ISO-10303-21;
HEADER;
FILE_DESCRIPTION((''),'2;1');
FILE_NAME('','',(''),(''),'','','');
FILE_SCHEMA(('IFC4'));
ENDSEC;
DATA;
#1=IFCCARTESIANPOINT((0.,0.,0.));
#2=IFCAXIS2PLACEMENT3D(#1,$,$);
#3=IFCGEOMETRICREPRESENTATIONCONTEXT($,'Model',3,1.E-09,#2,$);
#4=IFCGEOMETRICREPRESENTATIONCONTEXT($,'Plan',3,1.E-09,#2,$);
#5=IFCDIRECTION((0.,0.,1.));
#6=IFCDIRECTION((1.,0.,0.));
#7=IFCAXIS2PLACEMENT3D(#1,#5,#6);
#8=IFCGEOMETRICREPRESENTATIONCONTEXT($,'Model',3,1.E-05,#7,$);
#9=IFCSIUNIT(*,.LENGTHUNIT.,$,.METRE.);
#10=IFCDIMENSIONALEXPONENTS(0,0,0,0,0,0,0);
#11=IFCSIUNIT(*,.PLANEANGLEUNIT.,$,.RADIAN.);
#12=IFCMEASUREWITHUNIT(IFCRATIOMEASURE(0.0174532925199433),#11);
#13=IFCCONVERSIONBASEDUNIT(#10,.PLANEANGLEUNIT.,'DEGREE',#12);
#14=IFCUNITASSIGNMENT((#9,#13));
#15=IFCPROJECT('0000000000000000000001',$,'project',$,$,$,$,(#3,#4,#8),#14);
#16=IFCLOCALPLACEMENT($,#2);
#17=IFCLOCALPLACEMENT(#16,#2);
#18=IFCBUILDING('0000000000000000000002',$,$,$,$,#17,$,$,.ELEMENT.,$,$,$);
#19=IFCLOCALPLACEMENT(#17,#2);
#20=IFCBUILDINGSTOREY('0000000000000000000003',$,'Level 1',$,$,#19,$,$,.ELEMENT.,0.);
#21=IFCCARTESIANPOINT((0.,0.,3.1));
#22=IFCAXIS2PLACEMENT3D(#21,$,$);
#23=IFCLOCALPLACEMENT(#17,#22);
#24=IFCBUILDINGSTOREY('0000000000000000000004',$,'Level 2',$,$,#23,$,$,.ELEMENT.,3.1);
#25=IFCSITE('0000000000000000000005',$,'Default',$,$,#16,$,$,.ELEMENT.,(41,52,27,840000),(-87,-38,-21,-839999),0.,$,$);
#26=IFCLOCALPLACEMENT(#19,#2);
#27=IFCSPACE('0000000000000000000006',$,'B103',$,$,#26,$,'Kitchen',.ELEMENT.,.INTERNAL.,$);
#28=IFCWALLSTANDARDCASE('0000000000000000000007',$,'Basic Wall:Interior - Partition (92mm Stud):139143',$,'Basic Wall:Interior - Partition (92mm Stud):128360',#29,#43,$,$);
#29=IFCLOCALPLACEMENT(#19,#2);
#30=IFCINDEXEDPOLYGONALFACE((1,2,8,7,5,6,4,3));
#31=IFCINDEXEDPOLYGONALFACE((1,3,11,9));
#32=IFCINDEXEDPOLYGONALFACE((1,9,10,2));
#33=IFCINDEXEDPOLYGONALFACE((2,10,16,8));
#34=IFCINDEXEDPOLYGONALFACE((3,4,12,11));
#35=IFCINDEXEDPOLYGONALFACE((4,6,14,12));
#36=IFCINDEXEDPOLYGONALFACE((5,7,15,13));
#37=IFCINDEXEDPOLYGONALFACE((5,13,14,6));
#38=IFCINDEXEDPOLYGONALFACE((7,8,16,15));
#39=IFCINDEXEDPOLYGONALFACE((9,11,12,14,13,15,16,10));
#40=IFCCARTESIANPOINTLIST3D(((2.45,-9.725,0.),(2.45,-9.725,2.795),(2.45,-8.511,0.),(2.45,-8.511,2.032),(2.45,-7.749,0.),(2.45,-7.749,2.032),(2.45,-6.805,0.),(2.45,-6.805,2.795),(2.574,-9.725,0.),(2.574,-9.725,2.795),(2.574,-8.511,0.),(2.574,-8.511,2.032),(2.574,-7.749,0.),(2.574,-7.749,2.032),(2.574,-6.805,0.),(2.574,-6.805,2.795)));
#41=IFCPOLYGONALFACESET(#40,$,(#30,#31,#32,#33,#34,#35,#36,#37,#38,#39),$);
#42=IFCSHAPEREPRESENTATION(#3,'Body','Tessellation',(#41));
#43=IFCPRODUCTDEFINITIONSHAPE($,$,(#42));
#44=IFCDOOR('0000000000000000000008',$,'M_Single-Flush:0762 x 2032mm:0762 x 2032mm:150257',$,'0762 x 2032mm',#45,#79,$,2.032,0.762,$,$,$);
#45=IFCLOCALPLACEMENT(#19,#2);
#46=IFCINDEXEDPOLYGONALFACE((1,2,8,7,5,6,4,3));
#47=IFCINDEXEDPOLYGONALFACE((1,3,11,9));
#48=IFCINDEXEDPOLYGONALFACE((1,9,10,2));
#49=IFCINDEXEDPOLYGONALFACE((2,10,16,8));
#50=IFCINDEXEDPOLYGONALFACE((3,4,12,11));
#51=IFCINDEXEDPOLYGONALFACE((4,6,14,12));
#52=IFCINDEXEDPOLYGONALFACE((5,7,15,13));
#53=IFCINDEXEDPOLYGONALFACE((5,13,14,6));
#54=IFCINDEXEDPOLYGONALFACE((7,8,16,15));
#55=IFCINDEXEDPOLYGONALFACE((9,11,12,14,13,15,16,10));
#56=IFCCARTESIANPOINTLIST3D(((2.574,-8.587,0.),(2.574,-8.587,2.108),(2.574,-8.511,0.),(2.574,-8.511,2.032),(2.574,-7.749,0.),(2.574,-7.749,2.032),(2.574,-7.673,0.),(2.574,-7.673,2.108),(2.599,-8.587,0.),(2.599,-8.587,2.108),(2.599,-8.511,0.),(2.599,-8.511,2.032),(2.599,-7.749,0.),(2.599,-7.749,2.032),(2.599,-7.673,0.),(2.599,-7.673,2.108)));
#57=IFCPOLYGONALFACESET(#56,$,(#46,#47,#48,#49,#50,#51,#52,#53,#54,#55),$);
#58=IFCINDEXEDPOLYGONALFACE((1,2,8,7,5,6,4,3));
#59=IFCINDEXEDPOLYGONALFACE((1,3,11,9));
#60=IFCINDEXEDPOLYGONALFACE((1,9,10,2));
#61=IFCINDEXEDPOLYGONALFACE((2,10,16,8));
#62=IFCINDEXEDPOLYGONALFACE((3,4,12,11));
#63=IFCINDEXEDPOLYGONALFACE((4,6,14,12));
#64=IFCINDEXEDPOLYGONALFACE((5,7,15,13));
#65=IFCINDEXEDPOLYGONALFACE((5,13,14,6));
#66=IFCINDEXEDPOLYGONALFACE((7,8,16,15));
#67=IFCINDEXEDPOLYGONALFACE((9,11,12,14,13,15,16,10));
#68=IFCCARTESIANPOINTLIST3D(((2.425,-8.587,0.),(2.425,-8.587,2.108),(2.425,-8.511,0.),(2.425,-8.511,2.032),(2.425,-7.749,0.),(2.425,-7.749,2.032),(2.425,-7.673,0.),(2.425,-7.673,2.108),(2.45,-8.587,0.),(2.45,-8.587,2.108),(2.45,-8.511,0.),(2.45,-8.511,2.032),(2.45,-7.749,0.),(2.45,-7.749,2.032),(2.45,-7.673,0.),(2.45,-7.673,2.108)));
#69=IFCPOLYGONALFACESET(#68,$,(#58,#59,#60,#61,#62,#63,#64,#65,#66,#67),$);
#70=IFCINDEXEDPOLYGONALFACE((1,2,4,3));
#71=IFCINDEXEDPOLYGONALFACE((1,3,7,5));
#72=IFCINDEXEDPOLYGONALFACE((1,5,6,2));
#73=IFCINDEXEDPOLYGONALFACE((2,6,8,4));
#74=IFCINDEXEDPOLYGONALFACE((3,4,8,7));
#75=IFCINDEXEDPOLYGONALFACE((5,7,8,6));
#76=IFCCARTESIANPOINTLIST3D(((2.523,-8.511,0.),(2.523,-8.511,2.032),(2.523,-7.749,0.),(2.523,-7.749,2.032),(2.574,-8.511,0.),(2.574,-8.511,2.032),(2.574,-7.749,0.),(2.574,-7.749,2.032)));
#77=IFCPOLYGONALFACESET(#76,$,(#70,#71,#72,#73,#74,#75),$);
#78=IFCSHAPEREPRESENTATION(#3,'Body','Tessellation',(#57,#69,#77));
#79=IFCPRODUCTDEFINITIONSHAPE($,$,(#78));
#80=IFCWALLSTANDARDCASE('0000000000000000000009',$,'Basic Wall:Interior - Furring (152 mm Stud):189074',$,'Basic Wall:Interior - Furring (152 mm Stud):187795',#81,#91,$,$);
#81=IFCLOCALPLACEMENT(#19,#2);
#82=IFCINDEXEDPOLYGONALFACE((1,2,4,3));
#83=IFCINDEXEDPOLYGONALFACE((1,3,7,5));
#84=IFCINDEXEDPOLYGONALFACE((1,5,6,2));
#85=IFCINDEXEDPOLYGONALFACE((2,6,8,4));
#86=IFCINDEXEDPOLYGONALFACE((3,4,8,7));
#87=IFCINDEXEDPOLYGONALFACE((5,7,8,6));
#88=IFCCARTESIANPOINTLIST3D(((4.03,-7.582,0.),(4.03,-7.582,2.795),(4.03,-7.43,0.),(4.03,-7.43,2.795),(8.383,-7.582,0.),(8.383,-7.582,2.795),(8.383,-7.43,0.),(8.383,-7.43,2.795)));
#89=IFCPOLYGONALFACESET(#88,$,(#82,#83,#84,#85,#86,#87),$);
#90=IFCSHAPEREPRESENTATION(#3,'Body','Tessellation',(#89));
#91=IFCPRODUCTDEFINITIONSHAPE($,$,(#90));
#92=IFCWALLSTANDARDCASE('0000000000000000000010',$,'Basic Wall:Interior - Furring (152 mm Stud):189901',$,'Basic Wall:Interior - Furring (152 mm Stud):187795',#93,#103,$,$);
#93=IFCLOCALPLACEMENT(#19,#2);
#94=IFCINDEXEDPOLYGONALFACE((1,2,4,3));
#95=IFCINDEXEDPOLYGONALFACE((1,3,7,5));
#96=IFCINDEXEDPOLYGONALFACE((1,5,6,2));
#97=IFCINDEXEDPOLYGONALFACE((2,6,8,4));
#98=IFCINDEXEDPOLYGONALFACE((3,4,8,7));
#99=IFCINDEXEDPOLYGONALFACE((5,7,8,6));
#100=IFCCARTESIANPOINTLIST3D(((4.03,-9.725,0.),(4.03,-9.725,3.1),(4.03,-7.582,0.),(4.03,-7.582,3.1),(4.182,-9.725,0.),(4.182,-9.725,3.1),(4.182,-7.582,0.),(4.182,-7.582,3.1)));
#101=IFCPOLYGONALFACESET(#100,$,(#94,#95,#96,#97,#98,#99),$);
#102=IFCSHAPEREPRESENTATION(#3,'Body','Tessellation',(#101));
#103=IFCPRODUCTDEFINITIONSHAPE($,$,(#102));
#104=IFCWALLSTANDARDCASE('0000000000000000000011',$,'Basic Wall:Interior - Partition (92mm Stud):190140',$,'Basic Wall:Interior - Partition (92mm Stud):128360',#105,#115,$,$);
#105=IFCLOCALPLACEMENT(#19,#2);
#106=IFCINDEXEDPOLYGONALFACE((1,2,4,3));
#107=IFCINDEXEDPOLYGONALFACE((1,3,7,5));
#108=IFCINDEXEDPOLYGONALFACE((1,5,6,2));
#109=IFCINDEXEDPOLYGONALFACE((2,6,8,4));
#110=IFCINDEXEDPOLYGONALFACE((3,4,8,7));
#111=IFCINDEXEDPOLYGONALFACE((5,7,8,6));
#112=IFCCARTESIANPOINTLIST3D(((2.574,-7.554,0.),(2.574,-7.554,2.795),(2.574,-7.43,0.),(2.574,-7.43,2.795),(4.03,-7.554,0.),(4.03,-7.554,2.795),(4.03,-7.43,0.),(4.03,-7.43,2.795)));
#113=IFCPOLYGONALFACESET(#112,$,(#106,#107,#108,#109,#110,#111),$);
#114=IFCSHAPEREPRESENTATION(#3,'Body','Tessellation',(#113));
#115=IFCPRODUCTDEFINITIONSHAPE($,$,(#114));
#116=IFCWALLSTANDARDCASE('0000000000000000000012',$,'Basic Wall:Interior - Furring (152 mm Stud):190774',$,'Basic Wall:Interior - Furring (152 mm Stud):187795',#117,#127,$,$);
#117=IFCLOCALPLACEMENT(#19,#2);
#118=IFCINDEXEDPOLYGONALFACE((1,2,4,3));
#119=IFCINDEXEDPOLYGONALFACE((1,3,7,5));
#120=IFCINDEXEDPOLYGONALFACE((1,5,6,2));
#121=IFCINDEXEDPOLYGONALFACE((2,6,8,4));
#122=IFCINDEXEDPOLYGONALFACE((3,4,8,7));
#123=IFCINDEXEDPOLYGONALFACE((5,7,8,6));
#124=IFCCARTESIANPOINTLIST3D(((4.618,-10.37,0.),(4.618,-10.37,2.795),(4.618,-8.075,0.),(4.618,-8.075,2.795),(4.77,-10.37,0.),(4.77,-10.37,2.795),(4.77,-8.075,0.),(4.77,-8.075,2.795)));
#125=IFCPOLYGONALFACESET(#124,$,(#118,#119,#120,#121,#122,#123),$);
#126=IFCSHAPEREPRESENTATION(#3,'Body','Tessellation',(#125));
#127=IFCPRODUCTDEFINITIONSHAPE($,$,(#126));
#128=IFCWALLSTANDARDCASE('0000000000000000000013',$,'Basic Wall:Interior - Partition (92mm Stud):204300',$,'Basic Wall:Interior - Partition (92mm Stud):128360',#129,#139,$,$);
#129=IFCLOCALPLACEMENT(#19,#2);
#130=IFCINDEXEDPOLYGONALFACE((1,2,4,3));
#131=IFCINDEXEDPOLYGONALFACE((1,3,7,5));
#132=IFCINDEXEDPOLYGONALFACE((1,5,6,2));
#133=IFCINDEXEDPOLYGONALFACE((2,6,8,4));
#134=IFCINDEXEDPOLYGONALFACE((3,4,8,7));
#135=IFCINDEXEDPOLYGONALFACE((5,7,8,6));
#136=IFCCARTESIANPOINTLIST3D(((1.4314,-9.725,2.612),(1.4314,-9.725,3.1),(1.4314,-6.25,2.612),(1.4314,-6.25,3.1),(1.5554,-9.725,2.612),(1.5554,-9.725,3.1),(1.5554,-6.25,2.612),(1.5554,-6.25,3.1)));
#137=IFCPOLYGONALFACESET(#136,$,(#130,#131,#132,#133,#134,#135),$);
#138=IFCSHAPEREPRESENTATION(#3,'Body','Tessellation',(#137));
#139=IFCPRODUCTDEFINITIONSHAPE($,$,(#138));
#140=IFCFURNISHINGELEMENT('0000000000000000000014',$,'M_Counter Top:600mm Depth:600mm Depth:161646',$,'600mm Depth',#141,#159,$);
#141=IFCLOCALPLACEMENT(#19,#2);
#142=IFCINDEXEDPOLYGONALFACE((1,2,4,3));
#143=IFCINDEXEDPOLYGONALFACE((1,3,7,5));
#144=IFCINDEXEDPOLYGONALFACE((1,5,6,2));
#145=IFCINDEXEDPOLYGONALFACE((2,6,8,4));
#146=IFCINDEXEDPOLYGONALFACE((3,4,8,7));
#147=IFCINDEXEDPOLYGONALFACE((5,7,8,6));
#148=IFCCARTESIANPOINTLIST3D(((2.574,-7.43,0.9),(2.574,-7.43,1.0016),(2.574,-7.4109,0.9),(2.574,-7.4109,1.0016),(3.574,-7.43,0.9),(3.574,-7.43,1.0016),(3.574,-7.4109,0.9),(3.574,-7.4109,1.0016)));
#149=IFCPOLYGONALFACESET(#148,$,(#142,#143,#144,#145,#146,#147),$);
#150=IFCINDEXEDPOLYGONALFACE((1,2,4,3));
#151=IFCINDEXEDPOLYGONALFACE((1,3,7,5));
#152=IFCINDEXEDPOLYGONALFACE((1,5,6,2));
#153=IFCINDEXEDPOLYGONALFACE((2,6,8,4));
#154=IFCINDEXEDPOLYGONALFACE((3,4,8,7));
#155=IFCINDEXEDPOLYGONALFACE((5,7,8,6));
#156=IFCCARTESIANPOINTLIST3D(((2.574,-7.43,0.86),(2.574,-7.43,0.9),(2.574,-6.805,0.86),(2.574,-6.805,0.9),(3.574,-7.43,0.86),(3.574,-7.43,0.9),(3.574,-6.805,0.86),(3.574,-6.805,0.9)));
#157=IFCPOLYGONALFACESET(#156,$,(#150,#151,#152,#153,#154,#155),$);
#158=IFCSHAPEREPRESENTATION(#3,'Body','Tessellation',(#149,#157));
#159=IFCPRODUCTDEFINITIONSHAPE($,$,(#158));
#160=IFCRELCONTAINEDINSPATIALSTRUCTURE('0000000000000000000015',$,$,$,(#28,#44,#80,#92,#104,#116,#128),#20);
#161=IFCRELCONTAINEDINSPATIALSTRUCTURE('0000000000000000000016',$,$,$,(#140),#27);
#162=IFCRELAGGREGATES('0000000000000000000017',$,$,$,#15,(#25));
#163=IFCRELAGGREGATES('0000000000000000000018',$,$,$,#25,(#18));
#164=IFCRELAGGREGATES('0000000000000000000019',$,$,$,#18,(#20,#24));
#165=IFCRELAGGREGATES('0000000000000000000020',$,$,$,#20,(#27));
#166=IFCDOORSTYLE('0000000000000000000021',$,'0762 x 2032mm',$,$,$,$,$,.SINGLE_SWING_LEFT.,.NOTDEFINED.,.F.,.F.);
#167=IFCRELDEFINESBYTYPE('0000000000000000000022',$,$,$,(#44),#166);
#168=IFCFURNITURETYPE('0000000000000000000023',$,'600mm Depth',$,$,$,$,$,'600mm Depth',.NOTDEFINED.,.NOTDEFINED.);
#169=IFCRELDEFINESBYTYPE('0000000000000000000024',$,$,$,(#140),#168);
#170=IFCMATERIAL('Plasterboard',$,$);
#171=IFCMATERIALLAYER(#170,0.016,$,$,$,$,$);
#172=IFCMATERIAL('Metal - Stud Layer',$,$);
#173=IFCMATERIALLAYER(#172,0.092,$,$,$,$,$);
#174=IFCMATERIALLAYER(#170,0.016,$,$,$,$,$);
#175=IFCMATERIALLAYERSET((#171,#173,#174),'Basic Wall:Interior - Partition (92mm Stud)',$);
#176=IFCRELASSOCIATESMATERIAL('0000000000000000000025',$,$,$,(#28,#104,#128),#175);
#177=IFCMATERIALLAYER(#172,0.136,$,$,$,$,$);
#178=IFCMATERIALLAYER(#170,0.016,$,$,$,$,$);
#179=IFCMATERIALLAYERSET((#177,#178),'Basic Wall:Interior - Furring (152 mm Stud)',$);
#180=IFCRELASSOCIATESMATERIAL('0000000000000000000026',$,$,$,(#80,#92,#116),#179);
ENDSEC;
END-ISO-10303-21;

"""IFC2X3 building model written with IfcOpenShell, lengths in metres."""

from ifc_helpers import new_model, entity, si_unit, converted_unit, frame, frame_2d, origin, origin_with_axes, origin_2d_with_axis, place, context, project, spatial, polyline, rectangle, outline, extrude, clip, bounded_halfspace, source, transform, mapped, material, layer, layer_set, layer_usage, type_object, type_shapes, element, fill, save


model = new_model("IFC2X3")

# Units and contexts
model_context_1 = context("Model", 3, precision=1e-09, world=origin())
plan_context = context("Plan", 3, precision=1e-09, world=origin())
model_context_2 = context("Model", 3, precision=1e-05, world=origin_with_axes())
ifc_project = project(units=[si_unit("LENGTHUNIT", "METRE"), converted_unit("PLANEANGLEUNIT", "DEGREE", entity("IfcRatioMeasure", 0.0174532925199433), si_unit("PLANEANGLEUNIT", "RADIAN"), dimensions=[0, 0, 0, 0, 0, 0, 0])], contexts=[model_context_1, plan_context, model_context_2])

# Site, building, storey
site_placement = place(None, origin())
site = spatial("IfcSite", under=ifc_project, at=site_placement, Name="Default", CompositionType="ELEMENT", RefLatitude=(41, 52, 27, 840000), RefLongitude=(-87, -38, -21, -839999), RefElevation=0.0)
building_placement = place(site_placement, origin())
building = spatial("IfcBuilding", under=site, at=building_placement, CompositionType="ELEMENT")
storey_1_placement = place(building_placement, origin())
storey_1 = spatial("IfcBuildingStorey", under=building, at=storey_1_placement, Name="Level 1", CompositionType="ELEMENT", Elevation=0.0)

# Shared definitions
ifc_material_1 = material(Name="Metal - Stud Layer")
ifc_material_2 = material(Name="Plasterboard")

# Shared definitions
ifc_layer_1 = layer(ifc_material_2, 0.016)
ifc_layer_2 = layer(ifc_material_1, 0.092)
ifc_layer_3 = layer(ifc_material_2, 0.016)
ifc_layer_set_1 = layer_set([ifc_layer_1, ifc_layer_2, ifc_layer_3], Name="Basic Wall:Interior - Partition (92mm Stud)")

# Wall, opening, door
ifc_layer_usage_1 = layer_usage(ifc_layer_set_1, "AXIS2", "NEGATIVE", 0.062)
wall_1_placement = place(storey_1_placement, frame((2.512, -6.805, 0.0), z_axis=(0.0, 0.0, 1.0), x_axis=(0.0, -1.0, 0.0)))
wall_1 = element("IfcWallStandardCase", 1, at=wall_1_placement, inside=storey_1, material=ifc_layer_usage_1, Name="Basic Wall:Interior - Partition (92mm Stud):139143", ObjectType="Basic Wall:Interior - Partition (92mm Stud):128360", context=model_context_1, shape_type="SweptSolid", body=[
    extrude(rectangle(XDim=2.92, YDim=0.124, at=frame_2d((1.46, 0.0), x_axis=(-1.0, 0.0))), origin(), (0.0, 0.0, 1.0), 2.795),
])
opening_1_placement = place(wall_1_placement, frame((0.944, -0.062, 0.0)))
opening_1 = element("IfcOpeningElement", 2, at=opening_1_placement, cuts=wall_1, ObjectType="Opening", context=model_context_1, shape_type="SweptSolid", body=[
    extrude(rectangle(XDim=0.762, YDim=2.032, at=frame_2d((1.016, 0.381), x_axis=(0.0, -1.0))), frame((0.0, 0.0, 0.0), z_axis=(0.0, 1.0, 0.0), x_axis=(0.0, 0.0, 1.0)), (0.0, 0.0, 1.0), 0.124),
])
door_style_1 = type_object("IfcDoorStyle", Name="0762 x 2032mm", ConstructionType="NOTDEFINED", OperationType="SINGLE_SWING_LEFT", ParameterTakesPrecedence=False, Sizeable=False)
shared_shape_1 = source(origin(), model_context_1, "Body", "SweptSolid", [
    extrude(outline(polyline([(-0.457, -1.073), (0.457, -1.073), (0.457, 1.035), (0.381, 1.035), (0.381, -0.997), (-0.381, -0.997), (-0.381, 1.035), (-0.457, 1.035), (-0.457, -1.073)])), frame((0.381, 0.149, 1.035), z_axis=(0.0, -1.0, 0.0), x_axis=(-1.0, 0.0, 0.0)), (0.0, 0.0, 1.0), 0.025),
    extrude(outline(polyline([(-1.073, -0.457), (1.035, -0.457), (1.035, -0.381), (-0.997, -0.381), (-0.997, 0.381), (1.035, 0.381), (1.035, 0.457), (-1.073, 0.457), (-1.073, -0.457)])), frame((0.381, 0.0, 1.035), z_axis=(0.0, -1.0, 0.0), x_axis=(0.0, 0.0, -1.0)), (0.0, 0.0, 1.0), 0.025),
    extrude(rectangle(XDim=0.762, YDim=0.051, at=origin_2d_with_axis()), frame((0.381, 0.0985, 0.0)), (0.0, 0.0, 1.0), 2.032),
])
type_shapes(door_style_1, [shared_shape_1])
door_1_placement = place(opening_1_placement, origin())
door_1 = element("IfcDoor", 3, at=door_1_placement, inside=storey_1, type_object=door_style_1, Name="M_Single-Flush:0762 x 2032mm:0762 x 2032mm:150257", ObjectType="0762 x 2032mm", OverallHeight=2.032, OverallWidth=0.762, context=model_context_1, shape_type="MappedRepresentation", body=[
    mapped(shared_shape_1, transform((0.0, 0.0, 0.0), scale=1.0)),
])
fill(opening_1, door_1)

# Shared definitions
storey_2_placement = place(building_placement, frame((0.0, 0.0, 3.1)))
storey_2 = spatial("IfcBuildingStorey", under=building, at=storey_2_placement, Name="Level 2", CompositionType="ELEMENT", Elevation=3.1)

# Walls
ifc_layer_4 = layer(ifc_material_1, 0.136)
ifc_layer_5 = layer(ifc_material_2, 0.016)
ifc_layer_set_2 = layer_set([ifc_layer_4, ifc_layer_5], Name="Basic Wall:Interior - Furring (152 mm Stud)")
ifc_layer_usage_2 = layer_usage(ifc_layer_set_2, "AXIS2", "NEGATIVE", 0.076)
wall_2_placement = place(storey_1_placement, frame((8.383, -7.506, 0.0), z_axis=(0.0, 0.0, 1.0), x_axis=(-1.0, 0.0, 0.0)))
element("IfcWallStandardCase", 4, at=wall_2_placement, inside=storey_1, material=ifc_layer_usage_2, Name="Basic Wall:Interior - Furring (152 mm Stud):189074", ObjectType="Basic Wall:Interior - Furring (152 mm Stud):187795", context=model_context_1, shape_type="Clipping", body=[
    clip(extrude(rectangle(XDim=4.353, YDim=0.152, at=frame_2d((2.1765, 0.0), x_axis=(-1.0, 0.0))), origin(), (0.0, 0.0, 1.0), 2.795), bounded_halfspace(frame((0.0, -0.076, 2.795), z_axis=(0.0, 0.0, -1.0), x_axis=(0.0, 1.0, 0.0)), True, frame((0.0, -0.076, 2.795)), polyline([(0.0, 0.0), (3.708, 0.0), (3.708, 0.152), (0.0, 0.152), (0.0, 0.0)]))),
])
ifc_layer_usage_3 = layer_usage(ifc_layer_set_2, "AXIS2", "POSITIVE", -0.076)
wall_3_placement = place(storey_1_placement, frame((4.106, -9.725, 0.0), z_axis=(0.0, 0.0, 1.0), x_axis=(0.0, 1.0, 0.0)))
element("IfcWallStandardCase", 5, at=wall_3_placement, inside=storey_1, material=ifc_layer_usage_3, Name="Basic Wall:Interior - Furring (152 mm Stud):189901", ObjectType="Basic Wall:Interior - Furring (152 mm Stud):187795", context=model_context_1, shape_type="SweptSolid", body=[
    extrude(rectangle(XDim=2.143, YDim=0.152, at=frame_2d((1.0715, 0.0), x_axis=(-1.0, 0.0))), origin(), (0.0, 0.0, 1.0), 3.1),
])
ifc_layer_usage_4 = layer_usage(ifc_layer_set_1, "AXIS2", "NEGATIVE", 0.062)
wall_4_placement = place(storey_1_placement, frame((4.03, -7.492, 0.0), z_axis=(0.0, 0.0, 1.0), x_axis=(-1.0, 0.0, 0.0)))
element("IfcWallStandardCase", 6, at=wall_4_placement, inside=storey_1, material=ifc_layer_usage_4, Name="Basic Wall:Interior - Partition (92mm Stud):190140", ObjectType="Basic Wall:Interior - Partition (92mm Stud):128360", context=model_context_1, shape_type="SweptSolid", body=[
    extrude(rectangle(XDim=1.456, YDim=0.124, at=frame_2d((0.728, 0.0), x_axis=(-1.0, 0.0))), origin(), (0.0, 0.0, 1.0), 2.795),
])
ifc_layer_usage_5 = layer_usage(ifc_layer_set_2, "AXIS2", "POSITIVE", -0.076)
wall_5_placement = place(storey_1_placement, frame((4.694, -8.075, 0.0), z_axis=(0.0, 0.0, 1.0), x_axis=(0.0, -1.0, 0.0)))
element("IfcWallStandardCase", 7, at=wall_5_placement, inside=storey_1, material=ifc_layer_usage_5, Name="Basic Wall:Interior - Furring (152 mm Stud):190774", ObjectType="Basic Wall:Interior - Furring (152 mm Stud):187795", context=model_context_1, shape_type="SweptSolid", body=[
    extrude(rectangle(XDim=2.295, YDim=0.152, at=frame_2d((1.1475, 0.0), x_axis=(-1.0, 0.0))), origin(), (0.0, 0.0, 1.0), 2.795),
])
ifc_layer_usage_6 = layer_usage(ifc_layer_set_1, "AXIS2", "NEGATIVE", 0.062)
wall_6_placement = place(storey_1_placement, frame((1.4934, -6.25, 2.612), z_axis=(0.0, 0.0, 1.0), x_axis=(0.0, -1.0, 0.0)))
element("IfcWallStandardCase", 8, at=wall_6_placement, inside=storey_1, material=ifc_layer_usage_6, Name="Basic Wall:Interior - Partition (92mm Stud):204300", ObjectType="Basic Wall:Interior - Partition (92mm Stud):128360", context=model_context_1, shape_type="SweptSolid", body=[
    extrude(rectangle(XDim=3.475, YDim=0.124, at=frame_2d((1.7375, 0.0), x_axis=(-1.0, 0.0))), origin(), (0.0, 0.0, 1.0), 0.488),
])

# Shared definitions
space_1_placement = place(storey_1_placement, origin())
space_1 = spatial("IfcSpace", under=storey_1, at=space_1_placement, Name="B103", LongName="Kitchen", CompositionType="ELEMENT", InteriorOrExteriorSpace="INTERNAL")

# Furnishing element
furniture_type_1 = type_object("IfcFurnitureType", Name="600mm Depth", ElementType="600mm Depth", AssemblyPlace="NOTDEFINED")
shared_shape_2 = source(origin(), model_context_1, "Body", "SweptSolid", [
    extrude(rectangle(XDim=0.0191, YDim=1.0, at=origin_2d_with_axis()), frame((-0.7005, -0.0095, 0.9), z_axis=(0.0, 0.0, 1.0), x_axis=(0.0, -1.0, 0.0)), (0.0, 0.0, 1.0), 0.1016),
    extrude(rectangle(XDim=1.0, YDim=0.625, at=origin_2d_with_axis()), frame((-0.7005, -0.3125, 0.86), z_axis=(0.0, 0.0, 1.0), x_axis=(-1.0, 0.0, 0.0)), (0.0, 0.0, 1.0), 0.04),
])
type_shapes(furniture_type_1, [shared_shape_2])
furnishing_1_placement = place(space_1_placement, frame((2.3735, -7.43, 0.0), z_axis=(0.0, 0.0, 1.0), x_axis=(-1.0, 0.0, 0.0)))
element("IfcFurnishingElement", 9, at=furnishing_1_placement, inside=space_1, type_object=furniture_type_1, Name="M_Counter Top:600mm Depth:600mm Depth:161646", ObjectType="600mm Depth", context=model_context_1, shape_type="MappedRepresentation", body=[
    mapped(shared_shape_2, transform((0.0, 0.0, 0.0), scale=1.0)),
])

save(model, "model.ifc")
